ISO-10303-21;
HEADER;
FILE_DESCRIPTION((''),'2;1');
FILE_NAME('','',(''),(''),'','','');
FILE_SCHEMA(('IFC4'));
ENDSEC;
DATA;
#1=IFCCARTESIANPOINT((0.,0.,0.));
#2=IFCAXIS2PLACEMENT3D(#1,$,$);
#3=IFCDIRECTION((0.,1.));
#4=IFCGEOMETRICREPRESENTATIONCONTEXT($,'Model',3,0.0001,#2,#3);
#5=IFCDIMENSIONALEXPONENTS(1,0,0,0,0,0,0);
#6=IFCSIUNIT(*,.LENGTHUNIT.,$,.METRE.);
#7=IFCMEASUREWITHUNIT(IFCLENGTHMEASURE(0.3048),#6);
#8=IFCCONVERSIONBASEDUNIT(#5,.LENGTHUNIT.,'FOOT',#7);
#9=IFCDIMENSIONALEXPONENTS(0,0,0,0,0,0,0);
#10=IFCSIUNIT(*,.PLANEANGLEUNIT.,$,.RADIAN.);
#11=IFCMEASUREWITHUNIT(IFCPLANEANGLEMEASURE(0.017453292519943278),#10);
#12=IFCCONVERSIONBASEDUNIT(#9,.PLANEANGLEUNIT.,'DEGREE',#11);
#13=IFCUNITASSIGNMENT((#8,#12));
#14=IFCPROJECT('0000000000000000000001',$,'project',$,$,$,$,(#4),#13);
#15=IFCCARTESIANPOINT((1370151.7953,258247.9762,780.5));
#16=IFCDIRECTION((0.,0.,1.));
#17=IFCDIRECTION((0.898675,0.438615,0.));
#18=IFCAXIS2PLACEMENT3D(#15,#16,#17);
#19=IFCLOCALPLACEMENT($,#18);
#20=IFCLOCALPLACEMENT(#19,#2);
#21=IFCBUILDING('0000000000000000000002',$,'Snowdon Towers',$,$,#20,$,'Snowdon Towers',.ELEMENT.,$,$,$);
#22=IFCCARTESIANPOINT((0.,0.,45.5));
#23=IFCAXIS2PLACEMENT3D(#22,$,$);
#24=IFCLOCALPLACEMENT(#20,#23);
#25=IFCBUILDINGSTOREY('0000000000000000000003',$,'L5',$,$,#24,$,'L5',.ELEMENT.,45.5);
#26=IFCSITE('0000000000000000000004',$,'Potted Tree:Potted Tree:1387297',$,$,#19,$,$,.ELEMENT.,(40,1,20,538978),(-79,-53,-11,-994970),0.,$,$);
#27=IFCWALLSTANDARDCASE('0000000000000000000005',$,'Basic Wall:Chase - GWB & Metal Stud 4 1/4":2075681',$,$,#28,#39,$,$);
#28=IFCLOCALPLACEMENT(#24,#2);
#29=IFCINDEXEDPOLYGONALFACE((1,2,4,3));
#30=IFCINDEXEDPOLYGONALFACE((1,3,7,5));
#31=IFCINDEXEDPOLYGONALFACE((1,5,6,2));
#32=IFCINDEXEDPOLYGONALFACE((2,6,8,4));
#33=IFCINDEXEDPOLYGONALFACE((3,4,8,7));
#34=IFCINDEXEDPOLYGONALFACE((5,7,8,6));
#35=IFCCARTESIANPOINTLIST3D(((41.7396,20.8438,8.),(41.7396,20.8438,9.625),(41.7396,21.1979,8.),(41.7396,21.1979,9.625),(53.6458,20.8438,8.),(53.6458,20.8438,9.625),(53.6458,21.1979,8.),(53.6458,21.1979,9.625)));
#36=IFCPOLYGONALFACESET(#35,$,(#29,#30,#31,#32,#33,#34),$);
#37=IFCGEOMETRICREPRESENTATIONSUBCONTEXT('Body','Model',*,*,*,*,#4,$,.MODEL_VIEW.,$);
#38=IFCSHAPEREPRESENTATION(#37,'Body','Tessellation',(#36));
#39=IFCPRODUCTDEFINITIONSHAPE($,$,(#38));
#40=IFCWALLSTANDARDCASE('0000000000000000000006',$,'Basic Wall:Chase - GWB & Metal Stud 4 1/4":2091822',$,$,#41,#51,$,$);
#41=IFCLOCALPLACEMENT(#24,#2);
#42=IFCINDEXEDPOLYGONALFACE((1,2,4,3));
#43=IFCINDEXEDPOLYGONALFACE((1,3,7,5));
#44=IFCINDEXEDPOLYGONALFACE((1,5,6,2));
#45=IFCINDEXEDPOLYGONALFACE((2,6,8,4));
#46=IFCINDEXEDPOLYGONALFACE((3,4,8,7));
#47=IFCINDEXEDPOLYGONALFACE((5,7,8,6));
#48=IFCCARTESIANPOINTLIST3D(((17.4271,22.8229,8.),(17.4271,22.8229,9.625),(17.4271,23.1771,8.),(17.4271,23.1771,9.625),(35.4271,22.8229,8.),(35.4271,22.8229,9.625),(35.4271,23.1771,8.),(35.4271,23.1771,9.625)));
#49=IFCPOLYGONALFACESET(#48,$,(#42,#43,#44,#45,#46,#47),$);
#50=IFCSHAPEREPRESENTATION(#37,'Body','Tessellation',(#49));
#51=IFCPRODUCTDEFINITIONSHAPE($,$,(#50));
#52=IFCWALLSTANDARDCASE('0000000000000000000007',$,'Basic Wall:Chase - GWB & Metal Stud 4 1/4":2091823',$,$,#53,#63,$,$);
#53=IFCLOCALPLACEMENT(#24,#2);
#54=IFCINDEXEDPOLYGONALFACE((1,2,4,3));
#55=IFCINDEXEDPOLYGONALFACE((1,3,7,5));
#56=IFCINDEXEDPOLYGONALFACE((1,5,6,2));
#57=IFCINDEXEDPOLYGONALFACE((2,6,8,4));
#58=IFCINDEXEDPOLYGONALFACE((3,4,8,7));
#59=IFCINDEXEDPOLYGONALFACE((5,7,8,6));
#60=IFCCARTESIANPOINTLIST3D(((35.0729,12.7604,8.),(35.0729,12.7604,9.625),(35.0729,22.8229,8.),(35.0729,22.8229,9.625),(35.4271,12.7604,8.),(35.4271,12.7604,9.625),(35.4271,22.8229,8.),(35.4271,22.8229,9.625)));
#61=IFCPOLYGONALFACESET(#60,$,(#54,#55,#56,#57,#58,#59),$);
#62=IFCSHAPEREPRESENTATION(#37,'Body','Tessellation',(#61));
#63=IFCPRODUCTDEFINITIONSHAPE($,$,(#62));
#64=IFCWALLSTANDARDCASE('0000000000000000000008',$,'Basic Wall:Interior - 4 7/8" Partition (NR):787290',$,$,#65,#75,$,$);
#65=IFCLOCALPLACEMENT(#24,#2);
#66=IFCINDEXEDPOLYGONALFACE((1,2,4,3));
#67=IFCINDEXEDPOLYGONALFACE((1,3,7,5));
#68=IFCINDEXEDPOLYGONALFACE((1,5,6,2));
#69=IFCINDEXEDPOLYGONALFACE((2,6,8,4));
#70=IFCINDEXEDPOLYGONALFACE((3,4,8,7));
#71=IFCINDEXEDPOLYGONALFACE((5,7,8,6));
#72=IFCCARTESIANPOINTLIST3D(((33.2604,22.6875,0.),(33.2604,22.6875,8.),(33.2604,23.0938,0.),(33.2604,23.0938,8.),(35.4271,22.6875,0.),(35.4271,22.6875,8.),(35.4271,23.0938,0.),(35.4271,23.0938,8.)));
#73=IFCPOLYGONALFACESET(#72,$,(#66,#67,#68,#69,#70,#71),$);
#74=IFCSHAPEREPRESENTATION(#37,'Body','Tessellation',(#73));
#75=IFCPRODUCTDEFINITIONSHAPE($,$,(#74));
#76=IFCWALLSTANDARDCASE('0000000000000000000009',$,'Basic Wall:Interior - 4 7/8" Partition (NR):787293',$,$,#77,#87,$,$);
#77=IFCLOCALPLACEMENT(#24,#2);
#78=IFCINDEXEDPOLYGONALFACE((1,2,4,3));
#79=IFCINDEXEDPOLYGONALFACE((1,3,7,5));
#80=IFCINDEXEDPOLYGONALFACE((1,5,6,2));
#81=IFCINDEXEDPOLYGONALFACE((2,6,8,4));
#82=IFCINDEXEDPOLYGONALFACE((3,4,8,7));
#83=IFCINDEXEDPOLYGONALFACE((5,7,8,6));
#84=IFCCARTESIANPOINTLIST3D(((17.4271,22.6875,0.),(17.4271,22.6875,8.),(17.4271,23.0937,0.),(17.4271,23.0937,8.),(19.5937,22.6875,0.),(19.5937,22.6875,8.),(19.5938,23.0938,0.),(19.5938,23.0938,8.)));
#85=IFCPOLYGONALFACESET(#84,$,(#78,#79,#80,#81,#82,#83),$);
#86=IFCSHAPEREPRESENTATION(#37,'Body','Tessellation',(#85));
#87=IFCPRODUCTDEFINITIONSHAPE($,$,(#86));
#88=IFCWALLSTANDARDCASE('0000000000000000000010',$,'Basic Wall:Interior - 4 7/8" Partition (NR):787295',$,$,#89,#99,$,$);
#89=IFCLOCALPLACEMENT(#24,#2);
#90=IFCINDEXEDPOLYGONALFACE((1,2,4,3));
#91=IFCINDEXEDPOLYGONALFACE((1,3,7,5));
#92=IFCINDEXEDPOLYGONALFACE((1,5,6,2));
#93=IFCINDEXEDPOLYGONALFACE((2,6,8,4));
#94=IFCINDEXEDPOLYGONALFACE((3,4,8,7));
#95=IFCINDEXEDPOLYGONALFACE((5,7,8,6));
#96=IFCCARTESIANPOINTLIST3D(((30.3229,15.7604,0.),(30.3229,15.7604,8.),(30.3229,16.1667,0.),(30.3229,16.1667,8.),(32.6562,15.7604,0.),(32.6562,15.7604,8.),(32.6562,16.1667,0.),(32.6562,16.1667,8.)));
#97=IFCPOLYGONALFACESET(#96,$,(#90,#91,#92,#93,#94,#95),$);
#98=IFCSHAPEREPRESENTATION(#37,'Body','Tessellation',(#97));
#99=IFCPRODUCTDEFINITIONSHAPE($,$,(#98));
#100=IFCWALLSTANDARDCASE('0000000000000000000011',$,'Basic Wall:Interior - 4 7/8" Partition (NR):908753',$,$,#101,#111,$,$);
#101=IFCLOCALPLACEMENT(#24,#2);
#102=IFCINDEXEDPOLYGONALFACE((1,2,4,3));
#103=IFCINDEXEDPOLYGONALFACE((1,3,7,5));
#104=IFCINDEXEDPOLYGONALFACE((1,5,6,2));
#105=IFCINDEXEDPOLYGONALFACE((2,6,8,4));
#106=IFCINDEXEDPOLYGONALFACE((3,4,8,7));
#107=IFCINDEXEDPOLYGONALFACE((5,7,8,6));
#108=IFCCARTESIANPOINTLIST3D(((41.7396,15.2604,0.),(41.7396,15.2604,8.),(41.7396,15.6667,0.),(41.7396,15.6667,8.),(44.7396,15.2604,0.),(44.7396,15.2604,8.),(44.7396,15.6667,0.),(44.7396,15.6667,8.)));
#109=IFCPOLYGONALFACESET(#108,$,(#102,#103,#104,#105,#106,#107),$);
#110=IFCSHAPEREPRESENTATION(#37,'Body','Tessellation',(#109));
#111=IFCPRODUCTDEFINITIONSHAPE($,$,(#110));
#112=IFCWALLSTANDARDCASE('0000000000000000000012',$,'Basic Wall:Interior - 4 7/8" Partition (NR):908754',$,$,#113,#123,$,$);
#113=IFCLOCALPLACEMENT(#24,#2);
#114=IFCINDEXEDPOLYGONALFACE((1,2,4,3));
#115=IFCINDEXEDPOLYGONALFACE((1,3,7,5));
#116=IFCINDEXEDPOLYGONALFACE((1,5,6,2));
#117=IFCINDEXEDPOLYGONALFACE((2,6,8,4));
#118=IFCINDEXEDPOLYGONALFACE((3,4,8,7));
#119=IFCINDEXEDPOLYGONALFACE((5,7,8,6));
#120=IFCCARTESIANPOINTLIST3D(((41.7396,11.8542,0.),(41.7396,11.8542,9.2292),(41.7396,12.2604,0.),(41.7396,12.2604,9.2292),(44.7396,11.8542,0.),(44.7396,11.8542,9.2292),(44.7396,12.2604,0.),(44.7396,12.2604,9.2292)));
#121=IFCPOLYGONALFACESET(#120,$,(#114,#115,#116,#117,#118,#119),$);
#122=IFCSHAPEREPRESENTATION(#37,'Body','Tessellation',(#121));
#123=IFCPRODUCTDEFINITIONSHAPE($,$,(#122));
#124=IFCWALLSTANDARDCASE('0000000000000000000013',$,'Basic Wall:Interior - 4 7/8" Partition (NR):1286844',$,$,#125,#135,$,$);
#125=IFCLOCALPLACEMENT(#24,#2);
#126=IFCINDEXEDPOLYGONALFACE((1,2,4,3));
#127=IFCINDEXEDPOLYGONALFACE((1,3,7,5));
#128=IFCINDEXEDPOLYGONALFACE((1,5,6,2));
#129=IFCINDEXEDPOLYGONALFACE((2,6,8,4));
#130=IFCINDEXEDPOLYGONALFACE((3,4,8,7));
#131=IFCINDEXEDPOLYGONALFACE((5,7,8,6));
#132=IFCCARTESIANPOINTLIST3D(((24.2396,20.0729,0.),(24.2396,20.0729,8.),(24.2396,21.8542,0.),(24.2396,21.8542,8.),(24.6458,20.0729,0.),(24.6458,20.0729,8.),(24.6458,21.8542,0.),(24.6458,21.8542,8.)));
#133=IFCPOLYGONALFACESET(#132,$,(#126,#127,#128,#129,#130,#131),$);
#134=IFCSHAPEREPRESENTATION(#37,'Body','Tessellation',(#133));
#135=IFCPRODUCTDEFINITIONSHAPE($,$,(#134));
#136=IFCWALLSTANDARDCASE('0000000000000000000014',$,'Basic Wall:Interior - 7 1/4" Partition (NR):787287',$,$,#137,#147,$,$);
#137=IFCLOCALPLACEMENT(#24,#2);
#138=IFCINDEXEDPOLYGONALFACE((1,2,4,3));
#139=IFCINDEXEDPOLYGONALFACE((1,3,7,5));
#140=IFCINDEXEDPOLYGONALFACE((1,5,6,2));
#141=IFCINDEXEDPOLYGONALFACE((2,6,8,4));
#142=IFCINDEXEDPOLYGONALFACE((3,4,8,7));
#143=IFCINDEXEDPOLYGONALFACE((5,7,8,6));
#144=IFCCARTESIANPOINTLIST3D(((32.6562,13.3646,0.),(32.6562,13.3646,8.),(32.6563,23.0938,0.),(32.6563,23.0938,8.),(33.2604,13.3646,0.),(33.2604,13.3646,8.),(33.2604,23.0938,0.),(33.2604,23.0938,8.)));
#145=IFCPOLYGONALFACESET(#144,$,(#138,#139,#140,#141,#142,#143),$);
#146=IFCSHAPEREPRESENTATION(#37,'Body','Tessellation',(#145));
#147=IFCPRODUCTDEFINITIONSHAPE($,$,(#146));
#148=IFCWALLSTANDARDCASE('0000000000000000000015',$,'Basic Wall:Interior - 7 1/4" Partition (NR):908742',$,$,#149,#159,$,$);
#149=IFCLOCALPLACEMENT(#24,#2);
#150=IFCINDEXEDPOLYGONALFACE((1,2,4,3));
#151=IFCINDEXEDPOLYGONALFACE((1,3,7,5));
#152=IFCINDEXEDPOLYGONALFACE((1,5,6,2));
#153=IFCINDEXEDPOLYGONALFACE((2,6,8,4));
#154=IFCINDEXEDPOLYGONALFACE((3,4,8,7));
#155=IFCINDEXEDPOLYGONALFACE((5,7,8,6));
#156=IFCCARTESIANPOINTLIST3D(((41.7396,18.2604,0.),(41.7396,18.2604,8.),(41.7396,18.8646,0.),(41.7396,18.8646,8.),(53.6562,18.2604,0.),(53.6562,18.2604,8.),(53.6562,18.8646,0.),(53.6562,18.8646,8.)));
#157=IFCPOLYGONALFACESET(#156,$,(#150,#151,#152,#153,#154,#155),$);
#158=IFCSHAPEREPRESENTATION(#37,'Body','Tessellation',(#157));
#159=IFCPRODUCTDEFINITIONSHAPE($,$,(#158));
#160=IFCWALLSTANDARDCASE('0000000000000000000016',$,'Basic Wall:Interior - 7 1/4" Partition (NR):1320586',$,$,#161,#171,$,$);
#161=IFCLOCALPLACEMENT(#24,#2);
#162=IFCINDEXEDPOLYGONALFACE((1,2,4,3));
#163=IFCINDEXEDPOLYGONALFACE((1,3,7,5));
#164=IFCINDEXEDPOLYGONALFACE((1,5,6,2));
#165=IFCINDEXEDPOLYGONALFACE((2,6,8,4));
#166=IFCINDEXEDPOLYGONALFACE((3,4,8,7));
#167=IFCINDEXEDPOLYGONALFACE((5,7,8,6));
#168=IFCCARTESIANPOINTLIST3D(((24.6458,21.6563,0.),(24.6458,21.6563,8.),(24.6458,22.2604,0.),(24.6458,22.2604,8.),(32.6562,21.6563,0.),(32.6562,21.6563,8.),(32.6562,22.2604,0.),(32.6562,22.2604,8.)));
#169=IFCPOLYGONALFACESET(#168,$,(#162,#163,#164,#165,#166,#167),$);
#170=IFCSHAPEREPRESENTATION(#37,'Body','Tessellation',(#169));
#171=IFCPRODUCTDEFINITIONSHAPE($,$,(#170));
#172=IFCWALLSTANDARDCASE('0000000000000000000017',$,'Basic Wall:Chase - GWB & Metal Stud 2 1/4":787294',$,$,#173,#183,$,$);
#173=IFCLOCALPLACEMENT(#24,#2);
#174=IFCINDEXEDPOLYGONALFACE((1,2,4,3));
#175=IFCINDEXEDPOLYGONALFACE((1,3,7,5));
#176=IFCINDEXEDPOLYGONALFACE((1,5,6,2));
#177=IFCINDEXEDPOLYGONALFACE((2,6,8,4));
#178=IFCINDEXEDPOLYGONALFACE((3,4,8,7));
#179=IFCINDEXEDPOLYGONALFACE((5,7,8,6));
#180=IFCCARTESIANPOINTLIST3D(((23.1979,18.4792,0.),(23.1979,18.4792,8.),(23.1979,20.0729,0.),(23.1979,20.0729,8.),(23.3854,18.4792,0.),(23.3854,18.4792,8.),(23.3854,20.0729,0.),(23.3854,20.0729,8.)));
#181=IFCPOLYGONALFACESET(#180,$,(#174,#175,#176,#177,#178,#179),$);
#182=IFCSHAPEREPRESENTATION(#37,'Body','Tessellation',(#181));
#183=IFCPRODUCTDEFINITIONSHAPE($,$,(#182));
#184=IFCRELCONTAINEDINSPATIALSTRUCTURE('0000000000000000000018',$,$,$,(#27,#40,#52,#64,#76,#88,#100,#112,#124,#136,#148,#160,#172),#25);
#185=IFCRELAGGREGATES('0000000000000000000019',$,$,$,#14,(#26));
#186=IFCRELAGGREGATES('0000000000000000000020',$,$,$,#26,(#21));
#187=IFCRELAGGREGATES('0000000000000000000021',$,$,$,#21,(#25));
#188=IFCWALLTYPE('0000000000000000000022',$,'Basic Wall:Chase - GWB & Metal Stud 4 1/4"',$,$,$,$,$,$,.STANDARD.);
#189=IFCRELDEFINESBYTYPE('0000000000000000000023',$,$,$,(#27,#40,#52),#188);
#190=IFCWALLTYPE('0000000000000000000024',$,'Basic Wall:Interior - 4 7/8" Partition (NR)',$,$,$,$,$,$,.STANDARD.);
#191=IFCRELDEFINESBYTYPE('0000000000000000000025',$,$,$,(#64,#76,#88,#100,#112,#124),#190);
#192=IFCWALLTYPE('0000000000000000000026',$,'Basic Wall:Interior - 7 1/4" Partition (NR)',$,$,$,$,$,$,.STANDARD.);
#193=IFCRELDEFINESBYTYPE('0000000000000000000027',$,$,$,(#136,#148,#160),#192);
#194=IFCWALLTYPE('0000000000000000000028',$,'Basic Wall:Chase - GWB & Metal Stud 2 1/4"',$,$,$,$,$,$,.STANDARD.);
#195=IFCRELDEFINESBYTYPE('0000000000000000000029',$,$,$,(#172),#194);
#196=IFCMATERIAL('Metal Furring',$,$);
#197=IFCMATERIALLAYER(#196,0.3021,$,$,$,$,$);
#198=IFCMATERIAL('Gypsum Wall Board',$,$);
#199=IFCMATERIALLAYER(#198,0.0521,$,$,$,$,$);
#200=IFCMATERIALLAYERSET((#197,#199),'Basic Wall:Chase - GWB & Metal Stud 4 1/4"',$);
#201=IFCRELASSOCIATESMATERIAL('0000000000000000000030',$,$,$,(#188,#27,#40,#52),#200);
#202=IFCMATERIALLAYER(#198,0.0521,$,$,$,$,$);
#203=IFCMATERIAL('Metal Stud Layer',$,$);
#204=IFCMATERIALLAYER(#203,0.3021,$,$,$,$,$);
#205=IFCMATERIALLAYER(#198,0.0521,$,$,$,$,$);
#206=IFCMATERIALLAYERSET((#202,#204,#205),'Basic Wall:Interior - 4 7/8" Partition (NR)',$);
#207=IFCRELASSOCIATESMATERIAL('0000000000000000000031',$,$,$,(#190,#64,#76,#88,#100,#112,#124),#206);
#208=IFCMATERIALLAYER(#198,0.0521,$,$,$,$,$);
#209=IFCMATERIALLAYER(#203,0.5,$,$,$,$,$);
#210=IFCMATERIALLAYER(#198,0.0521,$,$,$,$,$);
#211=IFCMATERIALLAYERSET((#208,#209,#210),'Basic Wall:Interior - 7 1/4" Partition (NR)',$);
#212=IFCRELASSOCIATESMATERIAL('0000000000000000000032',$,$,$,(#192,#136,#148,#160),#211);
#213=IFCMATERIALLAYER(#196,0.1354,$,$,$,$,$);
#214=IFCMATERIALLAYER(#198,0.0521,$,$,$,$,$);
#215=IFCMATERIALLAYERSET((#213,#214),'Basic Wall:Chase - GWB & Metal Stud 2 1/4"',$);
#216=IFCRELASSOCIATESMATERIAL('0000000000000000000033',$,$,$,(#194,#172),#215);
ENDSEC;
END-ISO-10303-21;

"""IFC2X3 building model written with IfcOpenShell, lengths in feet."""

from ifc_helpers import new_model, entity, si_unit, converted_unit, direction, frame, frame_2d, origin, place, context, subcontext, project, spatial, polyline, rectangle, extrude, clip, bounded_halfspace, material, layer, layer_set, layer_usage, type_object, element, save


model = new_model("IFC2X3")

# Units and contexts
model_context = context("Model", 3, precision=0.0001, world=origin(), true_north=direction((0.0, 1.0)))
body_context = subcontext(model_context, "Body", "Model", "MODEL_VIEW")
ifc_project = project(units=[converted_unit("LENGTHUNIT", "FOOT", entity("IfcLengthMeasure", 0.3048), si_unit("LENGTHUNIT", "METRE"), dimensions=[1, 0, 0, 0, 0, 0, 0]), converted_unit("PLANEANGLEUNIT", "DEGREE", entity("IfcPlaneAngleMeasure", 0.017453292519943278), si_unit("PLANEANGLEUNIT", "RADIAN"), dimensions=[0, 0, 0, 0, 0, 0, 0])], contexts=[model_context])

# Site, building, storey
site_placement = place(None, frame((1370151.7953, 258247.9762, 780.5), z_axis=(0.0, 0.0, 1.0), x_axis=(0.898675, 0.438615, 0.0)))
site = spatial("IfcSite", under=ifc_project, at=site_placement, Name="Potted Tree:Potted Tree:1387297", CompositionType="ELEMENT", RefLatitude=(40, 1, 20, 538978), RefLongitude=(-79, -53, -11, -994970), RefElevation=0.0)
building_placement = place(site_placement, origin())
building = spatial("IfcBuilding", under=site, at=building_placement, Name="Snowdon Towers", LongName="Snowdon Towers", CompositionType="ELEMENT")
storey_placement = place(building_placement, frame((0.0, 0.0, 45.5)))
storey = spatial("IfcBuildingStorey", under=building, at=storey_placement, Name="L5", LongName="L5", CompositionType="ELEMENT", Elevation=45.5)

# Walls
ifc_material_1 = material(Name="Metal Furring")
ifc_layer_1 = layer(ifc_material_1, 0.3021)
ifc_material_2 = material(Name="Gypsum Wall Board")
ifc_layer_2 = layer(ifc_material_2, 0.0521)
ifc_layer_set_1 = layer_set([ifc_layer_1, ifc_layer_2], Name="Basic Wall:Chase - GWB & Metal Stud 4 1/4\"")
ifc_layer_usage_1 = layer_usage(ifc_layer_set_1, "AXIS2", "POSITIVE", -0.1771)
wall_type_1 = type_object("IfcWallType", Name="Basic Wall:Chase - GWB & Metal Stud 4 1/4\"", PredefinedType="STANDARD", material=ifc_layer_set_1)
wall_1_placement = place(storey_placement, frame((41.7396, 21.0208, 8.0)))
element("IfcWallStandardCase", 1, at=wall_1_placement, inside=storey, type_object=wall_type_1, material=ifc_layer_usage_1, Name="Basic Wall:Chase - GWB & Metal Stud 4 1/4\":2075681", context=body_context, shape_type="SweptSolid", body=[
    extrude(rectangle(XDim=11.9063, YDim=0.3542, at=frame_2d((5.9531, 0.0), x_axis=(-1.0, 0.0))), origin(), (0.0, 0.0, 1.0), 1.625),
])
ifc_layer_usage_2 = layer_usage(ifc_layer_set_1, "AXIS2", "POSITIVE", -0.1771)
wall_2_placement = place(storey_placement, frame((17.4271, 23.0, 8.0)))
element("IfcWallStandardCase", 2, at=wall_2_placement, inside=storey, type_object=wall_type_1, material=ifc_layer_usage_2, Name="Basic Wall:Chase - GWB & Metal Stud 4 1/4\":2091822", context=body_context, shape_type="SweptSolid", body=[
    extrude(rectangle(XDim=18.0, YDim=0.3542, at=frame_2d((9.0, 0.0), x_axis=(-1.0, 0.0))), origin(), (0.0, 0.0, 1.0), 1.625),
])
ifc_layer_usage_3 = layer_usage(ifc_layer_set_1, "AXIS2", "POSITIVE", -0.1771)
wall_3_placement = place(storey_placement, frame((35.25, 22.8229, 8.0), z_axis=(0.0, 0.0, 1.0), x_axis=(0.0, -1.0, 0.0)))
element("IfcWallStandardCase", 3, at=wall_3_placement, inside=storey, type_object=wall_type_1, material=ifc_layer_usage_3, Name="Basic Wall:Chase - GWB & Metal Stud 4 1/4\":2091823", context=body_context, shape_type="SweptSolid", body=[
    extrude(rectangle(XDim=10.0625, YDim=0.3542, at=frame_2d((5.0313, 0.0), x_axis=(-1.0, 0.0))), origin(), (0.0, 0.0, 1.0), 1.625),
])
ifc_layer_3 = layer(ifc_material_2, 0.0521)
ifc_material_3 = material(Name="Metal Stud Layer")
ifc_layer_4 = layer(ifc_material_3, 0.3021)
ifc_layer_5 = layer(ifc_material_2, 0.0521)
ifc_layer_set_2 = layer_set([ifc_layer_3, ifc_layer_4, ifc_layer_5], Name="Basic Wall:Interior - 4 7/8\" Partition (NR)")
ifc_layer_usage_4 = layer_usage(ifc_layer_set_2, "AXIS2", "NEGATIVE", 0.2031)
wall_type_2 = type_object("IfcWallType", Name="Basic Wall:Interior - 4 7/8\" Partition (NR)", PredefinedType="STANDARD", material=ifc_layer_set_2)
wall_4_placement = place(storey_placement, frame((35.4271, 22.8906, 0.0), z_axis=(0.0, 0.0, 1.0), x_axis=(-1.0, 0.0, 0.0)))
element("IfcWallStandardCase", 4, at=wall_4_placement, inside=storey, type_object=wall_type_2, material=ifc_layer_usage_4, Name="Basic Wall:Interior - 4 7/8\" Partition (NR):787290", context=body_context, shape_type="SweptSolid", body=[
    extrude(rectangle(XDim=2.1667, YDim=0.4062, at=frame_2d((1.0833, 0.0), x_axis=(-1.0, 0.0))), origin(), (0.0, 0.0, 1.0), 8.0),
])
ifc_layer_usage_5 = layer_usage(ifc_layer_set_2, "AXIS2", "NEGATIVE", 0.2031)
wall_5_placement = place(storey_placement, frame((19.5938, 22.8906, 0.0), z_axis=(0.0, 0.0, 1.0), x_axis=(-1.0, 0.0, 0.0)))
element("IfcWallStandardCase", 5, at=wall_5_placement, inside=storey, type_object=wall_type_2, material=ifc_layer_usage_5, Name="Basic Wall:Interior - 4 7/8\" Partition (NR):787293", context=body_context, shape_type="SweptSolid", body=[
    extrude(rectangle(XDim=2.1667, YDim=0.4062, at=frame_2d((1.0833, 0.0), x_axis=(-1.0, 0.0))), origin(), (0.0, 0.0, 1.0), 8.0),
])
ifc_layer_usage_6 = layer_usage(ifc_layer_set_2, "AXIS2", "NEGATIVE", 0.2031)
wall_6_placement = place(storey_placement, frame((32.6563, 15.9635, 0.0), z_axis=(0.0, 0.0, 1.0), x_axis=(-1.0, 0.0, 0.0)))
element("IfcWallStandardCase", 6, at=wall_6_placement, inside=storey, type_object=wall_type_2, material=ifc_layer_usage_6, Name="Basic Wall:Interior - 4 7/8\" Partition (NR):787295", context=body_context, shape_type="SweptSolid", body=[
    extrude(rectangle(XDim=2.3333, YDim=0.4062, at=frame_2d((1.1667, 0.0), x_axis=(-1.0, 0.0))), origin(), (0.0, 0.0, 1.0), 8.0),
])
ifc_layer_usage_7 = layer_usage(ifc_layer_set_2, "AXIS2", "POSITIVE", -0.2031)
wall_7_placement = place(storey_placement, frame((41.7396, 15.4635, 0.0)))
element("IfcWallStandardCase", 7, at=wall_7_placement, inside=storey, type_object=wall_type_2, material=ifc_layer_usage_7, Name="Basic Wall:Interior - 4 7/8\" Partition (NR):908753", context=body_context, shape_type="SweptSolid", body=[
    extrude(rectangle(XDim=3.0, YDim=0.4062, at=frame_2d((1.5, 0.0), x_axis=(-1.0, 0.0))), origin(), (0.0, 0.0, 1.0), 8.0),
])
ifc_layer_usage_8 = layer_usage(ifc_layer_set_2, "AXIS2", "NEGATIVE", 0.2031)
wall_8_placement = place(storey_placement, frame((41.7396, 12.0573, 0.0)))
element("IfcWallStandardCase", 8, at=wall_8_placement, inside=storey, type_object=wall_type_2, material=ifc_layer_usage_8, Name="Basic Wall:Interior - 4 7/8\" Partition (NR):908754", context=body_context, shape_type="Clipping", body=[
    clip(extrude(rectangle(XDim=3.0, YDim=0.4062, at=frame_2d((1.5, 0.0), x_axis=(-1.0, 0.0))), origin(), (0.0, 0.0, 1.0), 9.2292), bounded_halfspace(frame((0.0, -0.2031, 9.2292), z_axis=(0.0, 0.0, -1.0), x_axis=(-1.0, 0.0, 0.0)), True, frame((0.0, -0.2031, 9.2292)), polyline([(0.0, 0.0), (3.0, 0.0), (3.0, 0.4062), (0.0, 0.4062), (0.0, 0.0)]))),
])
ifc_layer_usage_9 = layer_usage(ifc_layer_set_2, "AXIS2", "POSITIVE", -0.2031)
wall_9_placement = place(storey_placement, frame((24.4427, 21.8542, 0.0), z_axis=(0.0, 0.0, 1.0), x_axis=(0.0, -1.0, 0.0)))
element("IfcWallStandardCase", 9, at=wall_9_placement, inside=storey, type_object=wall_type_2, material=ifc_layer_usage_9, Name="Basic Wall:Interior - 4 7/8\" Partition (NR):1286844", context=body_context, shape_type="SweptSolid", body=[
    extrude(rectangle(XDim=1.7813, YDim=0.4062, at=frame_2d((0.8906, 0.0), x_axis=(-1.0, 0.0))), origin(), (0.0, 0.0, 1.0), 8.0),
])
ifc_layer_6 = layer(ifc_material_2, 0.0521)
ifc_layer_7 = layer(ifc_material_3, 0.5)
ifc_layer_8 = layer(ifc_material_2, 0.0521)
ifc_layer_set_3 = layer_set([ifc_layer_6, ifc_layer_7, ifc_layer_8], Name="Basic Wall:Interior - 7 1/4\" Partition (NR)")
ifc_layer_usage_10 = layer_usage(ifc_layer_set_3, "AXIS2", "NEGATIVE", 0.3021)
wall_type_3 = type_object("IfcWallType", Name="Basic Wall:Interior - 7 1/4\" Partition (NR)", PredefinedType="STANDARD", material=ifc_layer_set_3)
wall_10_placement = place(storey_placement, frame((32.9583, 23.0937, 0.0), z_axis=(0.0, 0.0, 1.0), x_axis=(0.0, -1.0, 0.0)))
element("IfcWallStandardCase", 10, at=wall_10_placement, inside=storey, type_object=wall_type_3, material=ifc_layer_usage_10, Name="Basic Wall:Interior - 7 1/4\" Partition (NR):787287", context=body_context, shape_type="SweptSolid", body=[
    extrude(rectangle(XDim=9.7292, YDim=0.6042, at=frame_2d((4.8646, 0.0), x_axis=(-1.0, 0.0))), origin(), (0.0, 0.0, 1.0), 8.0),
])
ifc_layer_usage_11 = layer_usage(ifc_layer_set_3, "AXIS2", "NEGATIVE", 0.3021)
wall_11_placement = place(storey_placement, frame((41.7396, 18.5625, 0.0)))
element("IfcWallStandardCase", 11, at=wall_11_placement, inside=storey, type_object=wall_type_3, material=ifc_layer_usage_11, Name="Basic Wall:Interior - 7 1/4\" Partition (NR):908742", context=body_context, shape_type="SweptSolid", body=[
    extrude(rectangle(XDim=11.9167, YDim=0.6042, at=frame_2d((5.9583, 0.0), x_axis=(-1.0, 0.0))), origin(), (0.0, 0.0, 1.0), 8.0),
])
ifc_layer_usage_12 = layer_usage(ifc_layer_set_3, "AXIS2", "NEGATIVE", 0.3021)
wall_12_placement = place(storey_placement, frame((24.6458, 21.9583, 0.0)))
element("IfcWallStandardCase", 12, at=wall_12_placement, inside=storey, type_object=wall_type_3, material=ifc_layer_usage_12, Name="Basic Wall:Interior - 7 1/4\" Partition (NR):1320586", context=body_context, shape_type="SweptSolid", body=[
    extrude(rectangle(XDim=8.0104, YDim=0.6042, at=frame_2d((4.0052, 0.0), x_axis=(-1.0, 0.0))), origin(), (0.0, 0.0, 1.0), 8.0),
])
ifc_layer_9 = layer(ifc_material_1, 0.1354)
ifc_layer_10 = layer(ifc_material_2, 0.0521)
ifc_layer_set_4 = layer_set([ifc_layer_9, ifc_layer_10], Name="Basic Wall:Chase - GWB & Metal Stud 2 1/4\"")
ifc_layer_usage_13 = layer_usage(ifc_layer_set_4, "AXIS2", "NEGATIVE", 0.0938)
wall_type_4 = type_object("IfcWallType", Name="Basic Wall:Chase - GWB & Metal Stud 2 1/4\"", PredefinedType="STANDARD", material=ifc_layer_set_4)
wall_13_placement = place(storey_placement, frame((23.2917, 20.0729, 0.0), z_axis=(0.0, 0.0, 1.0), x_axis=(0.0, -1.0, 0.0)))
element("IfcWallStandardCase", 13, at=wall_13_placement, inside=storey, type_object=wall_type_4, material=ifc_layer_usage_13, Name="Basic Wall:Chase - GWB & Metal Stud 2 1/4\":787294", context=body_context, shape_type="SweptSolid", body=[
    extrude(rectangle(XDim=1.5938, YDim=0.1875, at=frame_2d((0.7969, 0.0), x_axis=(-1.0, 0.0))), origin(), (0.0, 0.0, 1.0), 8.0),
])

save(model, "model.ifc")
